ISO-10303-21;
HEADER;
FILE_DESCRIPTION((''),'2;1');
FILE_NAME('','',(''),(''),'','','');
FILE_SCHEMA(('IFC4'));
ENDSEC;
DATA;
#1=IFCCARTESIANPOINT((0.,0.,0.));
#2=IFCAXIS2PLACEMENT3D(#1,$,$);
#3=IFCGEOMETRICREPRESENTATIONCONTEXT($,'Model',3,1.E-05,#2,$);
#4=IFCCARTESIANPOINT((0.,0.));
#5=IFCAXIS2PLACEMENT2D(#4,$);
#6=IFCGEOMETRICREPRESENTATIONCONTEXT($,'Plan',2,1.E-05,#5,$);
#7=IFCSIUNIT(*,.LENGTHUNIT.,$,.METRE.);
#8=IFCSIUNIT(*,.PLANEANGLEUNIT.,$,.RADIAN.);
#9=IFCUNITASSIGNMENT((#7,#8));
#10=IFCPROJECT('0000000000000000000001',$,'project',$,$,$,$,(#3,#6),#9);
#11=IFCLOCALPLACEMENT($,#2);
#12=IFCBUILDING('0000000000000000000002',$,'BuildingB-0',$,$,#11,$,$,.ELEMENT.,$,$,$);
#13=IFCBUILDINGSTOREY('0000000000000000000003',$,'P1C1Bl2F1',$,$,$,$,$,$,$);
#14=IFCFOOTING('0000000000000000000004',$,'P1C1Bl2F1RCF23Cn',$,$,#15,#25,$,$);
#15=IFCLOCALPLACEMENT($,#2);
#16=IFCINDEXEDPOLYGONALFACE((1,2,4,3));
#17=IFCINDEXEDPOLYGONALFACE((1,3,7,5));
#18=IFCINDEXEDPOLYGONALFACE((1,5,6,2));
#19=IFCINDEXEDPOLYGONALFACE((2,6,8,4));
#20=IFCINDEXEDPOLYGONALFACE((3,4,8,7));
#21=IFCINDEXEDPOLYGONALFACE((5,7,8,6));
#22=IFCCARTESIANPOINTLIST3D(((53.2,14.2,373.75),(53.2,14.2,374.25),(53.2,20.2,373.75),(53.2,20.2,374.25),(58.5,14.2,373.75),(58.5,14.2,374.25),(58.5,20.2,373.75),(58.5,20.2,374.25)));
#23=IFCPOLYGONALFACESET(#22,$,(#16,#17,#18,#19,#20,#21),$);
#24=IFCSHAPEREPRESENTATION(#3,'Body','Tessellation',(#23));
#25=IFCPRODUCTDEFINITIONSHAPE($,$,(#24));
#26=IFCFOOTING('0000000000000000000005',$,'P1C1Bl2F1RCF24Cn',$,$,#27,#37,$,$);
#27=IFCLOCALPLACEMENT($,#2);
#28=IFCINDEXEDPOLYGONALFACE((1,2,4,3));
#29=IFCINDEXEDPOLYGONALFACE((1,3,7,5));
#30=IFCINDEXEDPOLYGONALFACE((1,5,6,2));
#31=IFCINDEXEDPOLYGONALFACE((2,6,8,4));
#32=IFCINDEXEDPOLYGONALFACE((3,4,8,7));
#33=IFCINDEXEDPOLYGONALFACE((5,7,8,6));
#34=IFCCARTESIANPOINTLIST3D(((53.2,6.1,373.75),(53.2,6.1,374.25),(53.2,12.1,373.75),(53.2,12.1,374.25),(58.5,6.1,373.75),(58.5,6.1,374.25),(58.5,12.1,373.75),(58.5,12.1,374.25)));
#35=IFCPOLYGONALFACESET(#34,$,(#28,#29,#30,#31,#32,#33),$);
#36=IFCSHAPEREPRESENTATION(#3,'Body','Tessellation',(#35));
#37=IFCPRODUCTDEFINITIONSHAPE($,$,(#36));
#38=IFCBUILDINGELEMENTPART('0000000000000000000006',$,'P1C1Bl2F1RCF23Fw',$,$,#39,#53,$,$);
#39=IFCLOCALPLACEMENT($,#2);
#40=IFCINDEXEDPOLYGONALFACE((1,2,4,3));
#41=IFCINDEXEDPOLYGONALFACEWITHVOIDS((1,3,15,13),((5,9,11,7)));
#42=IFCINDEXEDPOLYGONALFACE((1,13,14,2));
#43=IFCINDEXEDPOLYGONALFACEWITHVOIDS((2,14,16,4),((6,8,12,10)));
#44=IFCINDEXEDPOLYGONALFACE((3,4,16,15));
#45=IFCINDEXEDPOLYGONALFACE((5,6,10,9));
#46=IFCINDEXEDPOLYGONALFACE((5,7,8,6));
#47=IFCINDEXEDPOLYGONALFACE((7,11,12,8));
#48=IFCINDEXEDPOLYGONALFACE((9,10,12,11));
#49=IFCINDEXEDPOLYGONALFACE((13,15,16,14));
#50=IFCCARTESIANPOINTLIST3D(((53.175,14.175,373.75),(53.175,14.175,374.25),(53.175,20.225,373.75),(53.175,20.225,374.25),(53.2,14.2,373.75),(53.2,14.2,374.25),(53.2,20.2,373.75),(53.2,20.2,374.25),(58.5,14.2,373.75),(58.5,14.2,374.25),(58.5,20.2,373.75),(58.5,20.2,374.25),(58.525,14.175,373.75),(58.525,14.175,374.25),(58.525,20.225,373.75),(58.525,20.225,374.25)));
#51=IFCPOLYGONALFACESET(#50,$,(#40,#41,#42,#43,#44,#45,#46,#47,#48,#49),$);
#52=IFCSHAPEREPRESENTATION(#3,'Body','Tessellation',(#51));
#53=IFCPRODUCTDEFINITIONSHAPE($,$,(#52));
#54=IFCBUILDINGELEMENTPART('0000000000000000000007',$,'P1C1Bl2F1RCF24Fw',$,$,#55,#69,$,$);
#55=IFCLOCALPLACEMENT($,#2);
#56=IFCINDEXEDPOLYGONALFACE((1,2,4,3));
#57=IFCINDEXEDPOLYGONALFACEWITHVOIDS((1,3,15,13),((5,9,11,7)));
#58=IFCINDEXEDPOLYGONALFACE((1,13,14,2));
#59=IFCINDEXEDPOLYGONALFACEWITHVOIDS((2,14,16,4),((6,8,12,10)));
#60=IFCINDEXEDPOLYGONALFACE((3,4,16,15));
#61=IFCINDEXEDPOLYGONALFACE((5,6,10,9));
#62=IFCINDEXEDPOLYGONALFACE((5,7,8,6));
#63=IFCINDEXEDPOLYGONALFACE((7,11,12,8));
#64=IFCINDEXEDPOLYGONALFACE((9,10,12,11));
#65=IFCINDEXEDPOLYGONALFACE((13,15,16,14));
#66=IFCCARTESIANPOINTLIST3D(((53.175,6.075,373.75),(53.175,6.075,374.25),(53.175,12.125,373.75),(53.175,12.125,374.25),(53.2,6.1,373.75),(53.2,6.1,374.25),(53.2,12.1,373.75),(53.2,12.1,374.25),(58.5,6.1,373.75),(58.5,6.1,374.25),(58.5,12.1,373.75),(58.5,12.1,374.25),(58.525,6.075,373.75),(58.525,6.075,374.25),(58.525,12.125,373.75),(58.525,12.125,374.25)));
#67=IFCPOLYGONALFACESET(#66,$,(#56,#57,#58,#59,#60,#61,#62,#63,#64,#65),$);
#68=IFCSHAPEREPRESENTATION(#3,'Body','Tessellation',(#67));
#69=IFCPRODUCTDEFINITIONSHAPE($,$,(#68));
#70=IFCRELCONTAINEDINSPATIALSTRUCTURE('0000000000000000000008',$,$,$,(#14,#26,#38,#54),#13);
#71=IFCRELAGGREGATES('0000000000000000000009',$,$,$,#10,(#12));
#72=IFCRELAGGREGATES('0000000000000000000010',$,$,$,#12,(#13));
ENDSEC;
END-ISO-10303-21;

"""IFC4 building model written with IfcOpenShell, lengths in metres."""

from ifc_helpers import new_model, si_unit, origin, origin_2d, place, context, project, spatial, polyline, outline, extrude, element, save


model = new_model("IFC4")

# Units and contexts
model_context = context("Model", 3, precision=1e-05, world=origin())
plan_context = context("Plan", 2, precision=1e-05, world=origin_2d())
ifc_project = project(units=[si_unit("LENGTHUNIT", "METRE"), si_unit("PLANEANGLEUNIT", "RADIAN")], contexts=[model_context, plan_context])

# Building, storey
building_placement = place(None, origin())
building = spatial("IfcBuilding", under=ifc_project, at=building_placement, Name="BuildingB-0", CompositionType="ELEMENT")
storey = spatial("IfcBuildingStorey", under=building, Name="P1C1Bl2F1")

# Footings
element("IfcFooting", 1, inside=storey, Name="P1C1Bl2F1RCF23Cn", context=model_context, shape_type="SweptSolid", body=[
    extrude(outline(polyline([(58.5, 20.2, 373.75), (53.2, 20.2, 373.75), (53.2, 14.2, 373.75), (58.5, 14.2, 373.75), (58.5, 20.2, 373.75)])), None, (0.0, 0.0, 1.0), 0.5),
])
element("IfcFooting", 2, inside=storey, Name="P1C1Bl2F1RCF24Cn", context=model_context, shape_type="SweptSolid", body=[
    extrude(outline(polyline([(58.5, 12.1, 373.75), (53.2, 12.1, 373.75), (53.2, 6.1, 373.75), (58.5, 6.1, 373.75), (58.5, 12.1, 373.75)])), None, (0.0, 0.0, 1.0), 0.5),
])

# Building element part, opening
building_element_part_1 = element("IfcBuildingElementPart", 3, inside=storey, Name="P1C1Bl2F1RCF23Fw", context=model_context, shape_type="SweptSolid", body=[
    extrude(outline(polyline([(58.525, 20.225, 373.75), (53.175, 20.225, 373.75), (53.175, 14.175, 373.75), (58.525, 14.175, 373.75), (58.525, 20.225, 373.75)])), None, (0.0, 0.0, 1.0), 0.5),
])
element("IfcOpeningElement", 4, inside=storey, cuts=building_element_part_1, context=model_context, shape_type="SweptSolid", body=[
    extrude(outline(polyline([(58.5, 20.2, 373.75), (53.2, 20.2, 373.75), (53.2, 14.2, 373.75), (58.5, 14.2, 373.75), (58.5, 20.2, 373.75)])), None, (0.0, 0.0, 1.0), 0.5),
])

# Building element part, opening
building_element_part_2 = element("IfcBuildingElementPart", 5, inside=storey, Name="P1C1Bl2F1RCF24Fw", context=model_context, shape_type="SweptSolid", body=[
    extrude(outline(polyline([(58.525, 12.125, 373.75), (53.175, 12.125, 373.75), (53.175, 6.075, 373.75), (58.525, 6.075, 373.75), (58.525, 12.125, 373.75)])), None, (0.0, 0.0, 1.0), 0.5),
])
element("IfcOpeningElement", 6, inside=storey, cuts=building_element_part_2, context=model_context, shape_type="SweptSolid", body=[
    extrude(outline(polyline([(58.5, 12.1, 373.75), (53.2, 12.1, 373.75), (53.2, 6.1, 373.75), (58.5, 6.1, 373.75), (58.5, 12.1, 373.75)])), None, (0.0, 0.0, 1.0), 0.5),
])

save(model, "model.ifc")
